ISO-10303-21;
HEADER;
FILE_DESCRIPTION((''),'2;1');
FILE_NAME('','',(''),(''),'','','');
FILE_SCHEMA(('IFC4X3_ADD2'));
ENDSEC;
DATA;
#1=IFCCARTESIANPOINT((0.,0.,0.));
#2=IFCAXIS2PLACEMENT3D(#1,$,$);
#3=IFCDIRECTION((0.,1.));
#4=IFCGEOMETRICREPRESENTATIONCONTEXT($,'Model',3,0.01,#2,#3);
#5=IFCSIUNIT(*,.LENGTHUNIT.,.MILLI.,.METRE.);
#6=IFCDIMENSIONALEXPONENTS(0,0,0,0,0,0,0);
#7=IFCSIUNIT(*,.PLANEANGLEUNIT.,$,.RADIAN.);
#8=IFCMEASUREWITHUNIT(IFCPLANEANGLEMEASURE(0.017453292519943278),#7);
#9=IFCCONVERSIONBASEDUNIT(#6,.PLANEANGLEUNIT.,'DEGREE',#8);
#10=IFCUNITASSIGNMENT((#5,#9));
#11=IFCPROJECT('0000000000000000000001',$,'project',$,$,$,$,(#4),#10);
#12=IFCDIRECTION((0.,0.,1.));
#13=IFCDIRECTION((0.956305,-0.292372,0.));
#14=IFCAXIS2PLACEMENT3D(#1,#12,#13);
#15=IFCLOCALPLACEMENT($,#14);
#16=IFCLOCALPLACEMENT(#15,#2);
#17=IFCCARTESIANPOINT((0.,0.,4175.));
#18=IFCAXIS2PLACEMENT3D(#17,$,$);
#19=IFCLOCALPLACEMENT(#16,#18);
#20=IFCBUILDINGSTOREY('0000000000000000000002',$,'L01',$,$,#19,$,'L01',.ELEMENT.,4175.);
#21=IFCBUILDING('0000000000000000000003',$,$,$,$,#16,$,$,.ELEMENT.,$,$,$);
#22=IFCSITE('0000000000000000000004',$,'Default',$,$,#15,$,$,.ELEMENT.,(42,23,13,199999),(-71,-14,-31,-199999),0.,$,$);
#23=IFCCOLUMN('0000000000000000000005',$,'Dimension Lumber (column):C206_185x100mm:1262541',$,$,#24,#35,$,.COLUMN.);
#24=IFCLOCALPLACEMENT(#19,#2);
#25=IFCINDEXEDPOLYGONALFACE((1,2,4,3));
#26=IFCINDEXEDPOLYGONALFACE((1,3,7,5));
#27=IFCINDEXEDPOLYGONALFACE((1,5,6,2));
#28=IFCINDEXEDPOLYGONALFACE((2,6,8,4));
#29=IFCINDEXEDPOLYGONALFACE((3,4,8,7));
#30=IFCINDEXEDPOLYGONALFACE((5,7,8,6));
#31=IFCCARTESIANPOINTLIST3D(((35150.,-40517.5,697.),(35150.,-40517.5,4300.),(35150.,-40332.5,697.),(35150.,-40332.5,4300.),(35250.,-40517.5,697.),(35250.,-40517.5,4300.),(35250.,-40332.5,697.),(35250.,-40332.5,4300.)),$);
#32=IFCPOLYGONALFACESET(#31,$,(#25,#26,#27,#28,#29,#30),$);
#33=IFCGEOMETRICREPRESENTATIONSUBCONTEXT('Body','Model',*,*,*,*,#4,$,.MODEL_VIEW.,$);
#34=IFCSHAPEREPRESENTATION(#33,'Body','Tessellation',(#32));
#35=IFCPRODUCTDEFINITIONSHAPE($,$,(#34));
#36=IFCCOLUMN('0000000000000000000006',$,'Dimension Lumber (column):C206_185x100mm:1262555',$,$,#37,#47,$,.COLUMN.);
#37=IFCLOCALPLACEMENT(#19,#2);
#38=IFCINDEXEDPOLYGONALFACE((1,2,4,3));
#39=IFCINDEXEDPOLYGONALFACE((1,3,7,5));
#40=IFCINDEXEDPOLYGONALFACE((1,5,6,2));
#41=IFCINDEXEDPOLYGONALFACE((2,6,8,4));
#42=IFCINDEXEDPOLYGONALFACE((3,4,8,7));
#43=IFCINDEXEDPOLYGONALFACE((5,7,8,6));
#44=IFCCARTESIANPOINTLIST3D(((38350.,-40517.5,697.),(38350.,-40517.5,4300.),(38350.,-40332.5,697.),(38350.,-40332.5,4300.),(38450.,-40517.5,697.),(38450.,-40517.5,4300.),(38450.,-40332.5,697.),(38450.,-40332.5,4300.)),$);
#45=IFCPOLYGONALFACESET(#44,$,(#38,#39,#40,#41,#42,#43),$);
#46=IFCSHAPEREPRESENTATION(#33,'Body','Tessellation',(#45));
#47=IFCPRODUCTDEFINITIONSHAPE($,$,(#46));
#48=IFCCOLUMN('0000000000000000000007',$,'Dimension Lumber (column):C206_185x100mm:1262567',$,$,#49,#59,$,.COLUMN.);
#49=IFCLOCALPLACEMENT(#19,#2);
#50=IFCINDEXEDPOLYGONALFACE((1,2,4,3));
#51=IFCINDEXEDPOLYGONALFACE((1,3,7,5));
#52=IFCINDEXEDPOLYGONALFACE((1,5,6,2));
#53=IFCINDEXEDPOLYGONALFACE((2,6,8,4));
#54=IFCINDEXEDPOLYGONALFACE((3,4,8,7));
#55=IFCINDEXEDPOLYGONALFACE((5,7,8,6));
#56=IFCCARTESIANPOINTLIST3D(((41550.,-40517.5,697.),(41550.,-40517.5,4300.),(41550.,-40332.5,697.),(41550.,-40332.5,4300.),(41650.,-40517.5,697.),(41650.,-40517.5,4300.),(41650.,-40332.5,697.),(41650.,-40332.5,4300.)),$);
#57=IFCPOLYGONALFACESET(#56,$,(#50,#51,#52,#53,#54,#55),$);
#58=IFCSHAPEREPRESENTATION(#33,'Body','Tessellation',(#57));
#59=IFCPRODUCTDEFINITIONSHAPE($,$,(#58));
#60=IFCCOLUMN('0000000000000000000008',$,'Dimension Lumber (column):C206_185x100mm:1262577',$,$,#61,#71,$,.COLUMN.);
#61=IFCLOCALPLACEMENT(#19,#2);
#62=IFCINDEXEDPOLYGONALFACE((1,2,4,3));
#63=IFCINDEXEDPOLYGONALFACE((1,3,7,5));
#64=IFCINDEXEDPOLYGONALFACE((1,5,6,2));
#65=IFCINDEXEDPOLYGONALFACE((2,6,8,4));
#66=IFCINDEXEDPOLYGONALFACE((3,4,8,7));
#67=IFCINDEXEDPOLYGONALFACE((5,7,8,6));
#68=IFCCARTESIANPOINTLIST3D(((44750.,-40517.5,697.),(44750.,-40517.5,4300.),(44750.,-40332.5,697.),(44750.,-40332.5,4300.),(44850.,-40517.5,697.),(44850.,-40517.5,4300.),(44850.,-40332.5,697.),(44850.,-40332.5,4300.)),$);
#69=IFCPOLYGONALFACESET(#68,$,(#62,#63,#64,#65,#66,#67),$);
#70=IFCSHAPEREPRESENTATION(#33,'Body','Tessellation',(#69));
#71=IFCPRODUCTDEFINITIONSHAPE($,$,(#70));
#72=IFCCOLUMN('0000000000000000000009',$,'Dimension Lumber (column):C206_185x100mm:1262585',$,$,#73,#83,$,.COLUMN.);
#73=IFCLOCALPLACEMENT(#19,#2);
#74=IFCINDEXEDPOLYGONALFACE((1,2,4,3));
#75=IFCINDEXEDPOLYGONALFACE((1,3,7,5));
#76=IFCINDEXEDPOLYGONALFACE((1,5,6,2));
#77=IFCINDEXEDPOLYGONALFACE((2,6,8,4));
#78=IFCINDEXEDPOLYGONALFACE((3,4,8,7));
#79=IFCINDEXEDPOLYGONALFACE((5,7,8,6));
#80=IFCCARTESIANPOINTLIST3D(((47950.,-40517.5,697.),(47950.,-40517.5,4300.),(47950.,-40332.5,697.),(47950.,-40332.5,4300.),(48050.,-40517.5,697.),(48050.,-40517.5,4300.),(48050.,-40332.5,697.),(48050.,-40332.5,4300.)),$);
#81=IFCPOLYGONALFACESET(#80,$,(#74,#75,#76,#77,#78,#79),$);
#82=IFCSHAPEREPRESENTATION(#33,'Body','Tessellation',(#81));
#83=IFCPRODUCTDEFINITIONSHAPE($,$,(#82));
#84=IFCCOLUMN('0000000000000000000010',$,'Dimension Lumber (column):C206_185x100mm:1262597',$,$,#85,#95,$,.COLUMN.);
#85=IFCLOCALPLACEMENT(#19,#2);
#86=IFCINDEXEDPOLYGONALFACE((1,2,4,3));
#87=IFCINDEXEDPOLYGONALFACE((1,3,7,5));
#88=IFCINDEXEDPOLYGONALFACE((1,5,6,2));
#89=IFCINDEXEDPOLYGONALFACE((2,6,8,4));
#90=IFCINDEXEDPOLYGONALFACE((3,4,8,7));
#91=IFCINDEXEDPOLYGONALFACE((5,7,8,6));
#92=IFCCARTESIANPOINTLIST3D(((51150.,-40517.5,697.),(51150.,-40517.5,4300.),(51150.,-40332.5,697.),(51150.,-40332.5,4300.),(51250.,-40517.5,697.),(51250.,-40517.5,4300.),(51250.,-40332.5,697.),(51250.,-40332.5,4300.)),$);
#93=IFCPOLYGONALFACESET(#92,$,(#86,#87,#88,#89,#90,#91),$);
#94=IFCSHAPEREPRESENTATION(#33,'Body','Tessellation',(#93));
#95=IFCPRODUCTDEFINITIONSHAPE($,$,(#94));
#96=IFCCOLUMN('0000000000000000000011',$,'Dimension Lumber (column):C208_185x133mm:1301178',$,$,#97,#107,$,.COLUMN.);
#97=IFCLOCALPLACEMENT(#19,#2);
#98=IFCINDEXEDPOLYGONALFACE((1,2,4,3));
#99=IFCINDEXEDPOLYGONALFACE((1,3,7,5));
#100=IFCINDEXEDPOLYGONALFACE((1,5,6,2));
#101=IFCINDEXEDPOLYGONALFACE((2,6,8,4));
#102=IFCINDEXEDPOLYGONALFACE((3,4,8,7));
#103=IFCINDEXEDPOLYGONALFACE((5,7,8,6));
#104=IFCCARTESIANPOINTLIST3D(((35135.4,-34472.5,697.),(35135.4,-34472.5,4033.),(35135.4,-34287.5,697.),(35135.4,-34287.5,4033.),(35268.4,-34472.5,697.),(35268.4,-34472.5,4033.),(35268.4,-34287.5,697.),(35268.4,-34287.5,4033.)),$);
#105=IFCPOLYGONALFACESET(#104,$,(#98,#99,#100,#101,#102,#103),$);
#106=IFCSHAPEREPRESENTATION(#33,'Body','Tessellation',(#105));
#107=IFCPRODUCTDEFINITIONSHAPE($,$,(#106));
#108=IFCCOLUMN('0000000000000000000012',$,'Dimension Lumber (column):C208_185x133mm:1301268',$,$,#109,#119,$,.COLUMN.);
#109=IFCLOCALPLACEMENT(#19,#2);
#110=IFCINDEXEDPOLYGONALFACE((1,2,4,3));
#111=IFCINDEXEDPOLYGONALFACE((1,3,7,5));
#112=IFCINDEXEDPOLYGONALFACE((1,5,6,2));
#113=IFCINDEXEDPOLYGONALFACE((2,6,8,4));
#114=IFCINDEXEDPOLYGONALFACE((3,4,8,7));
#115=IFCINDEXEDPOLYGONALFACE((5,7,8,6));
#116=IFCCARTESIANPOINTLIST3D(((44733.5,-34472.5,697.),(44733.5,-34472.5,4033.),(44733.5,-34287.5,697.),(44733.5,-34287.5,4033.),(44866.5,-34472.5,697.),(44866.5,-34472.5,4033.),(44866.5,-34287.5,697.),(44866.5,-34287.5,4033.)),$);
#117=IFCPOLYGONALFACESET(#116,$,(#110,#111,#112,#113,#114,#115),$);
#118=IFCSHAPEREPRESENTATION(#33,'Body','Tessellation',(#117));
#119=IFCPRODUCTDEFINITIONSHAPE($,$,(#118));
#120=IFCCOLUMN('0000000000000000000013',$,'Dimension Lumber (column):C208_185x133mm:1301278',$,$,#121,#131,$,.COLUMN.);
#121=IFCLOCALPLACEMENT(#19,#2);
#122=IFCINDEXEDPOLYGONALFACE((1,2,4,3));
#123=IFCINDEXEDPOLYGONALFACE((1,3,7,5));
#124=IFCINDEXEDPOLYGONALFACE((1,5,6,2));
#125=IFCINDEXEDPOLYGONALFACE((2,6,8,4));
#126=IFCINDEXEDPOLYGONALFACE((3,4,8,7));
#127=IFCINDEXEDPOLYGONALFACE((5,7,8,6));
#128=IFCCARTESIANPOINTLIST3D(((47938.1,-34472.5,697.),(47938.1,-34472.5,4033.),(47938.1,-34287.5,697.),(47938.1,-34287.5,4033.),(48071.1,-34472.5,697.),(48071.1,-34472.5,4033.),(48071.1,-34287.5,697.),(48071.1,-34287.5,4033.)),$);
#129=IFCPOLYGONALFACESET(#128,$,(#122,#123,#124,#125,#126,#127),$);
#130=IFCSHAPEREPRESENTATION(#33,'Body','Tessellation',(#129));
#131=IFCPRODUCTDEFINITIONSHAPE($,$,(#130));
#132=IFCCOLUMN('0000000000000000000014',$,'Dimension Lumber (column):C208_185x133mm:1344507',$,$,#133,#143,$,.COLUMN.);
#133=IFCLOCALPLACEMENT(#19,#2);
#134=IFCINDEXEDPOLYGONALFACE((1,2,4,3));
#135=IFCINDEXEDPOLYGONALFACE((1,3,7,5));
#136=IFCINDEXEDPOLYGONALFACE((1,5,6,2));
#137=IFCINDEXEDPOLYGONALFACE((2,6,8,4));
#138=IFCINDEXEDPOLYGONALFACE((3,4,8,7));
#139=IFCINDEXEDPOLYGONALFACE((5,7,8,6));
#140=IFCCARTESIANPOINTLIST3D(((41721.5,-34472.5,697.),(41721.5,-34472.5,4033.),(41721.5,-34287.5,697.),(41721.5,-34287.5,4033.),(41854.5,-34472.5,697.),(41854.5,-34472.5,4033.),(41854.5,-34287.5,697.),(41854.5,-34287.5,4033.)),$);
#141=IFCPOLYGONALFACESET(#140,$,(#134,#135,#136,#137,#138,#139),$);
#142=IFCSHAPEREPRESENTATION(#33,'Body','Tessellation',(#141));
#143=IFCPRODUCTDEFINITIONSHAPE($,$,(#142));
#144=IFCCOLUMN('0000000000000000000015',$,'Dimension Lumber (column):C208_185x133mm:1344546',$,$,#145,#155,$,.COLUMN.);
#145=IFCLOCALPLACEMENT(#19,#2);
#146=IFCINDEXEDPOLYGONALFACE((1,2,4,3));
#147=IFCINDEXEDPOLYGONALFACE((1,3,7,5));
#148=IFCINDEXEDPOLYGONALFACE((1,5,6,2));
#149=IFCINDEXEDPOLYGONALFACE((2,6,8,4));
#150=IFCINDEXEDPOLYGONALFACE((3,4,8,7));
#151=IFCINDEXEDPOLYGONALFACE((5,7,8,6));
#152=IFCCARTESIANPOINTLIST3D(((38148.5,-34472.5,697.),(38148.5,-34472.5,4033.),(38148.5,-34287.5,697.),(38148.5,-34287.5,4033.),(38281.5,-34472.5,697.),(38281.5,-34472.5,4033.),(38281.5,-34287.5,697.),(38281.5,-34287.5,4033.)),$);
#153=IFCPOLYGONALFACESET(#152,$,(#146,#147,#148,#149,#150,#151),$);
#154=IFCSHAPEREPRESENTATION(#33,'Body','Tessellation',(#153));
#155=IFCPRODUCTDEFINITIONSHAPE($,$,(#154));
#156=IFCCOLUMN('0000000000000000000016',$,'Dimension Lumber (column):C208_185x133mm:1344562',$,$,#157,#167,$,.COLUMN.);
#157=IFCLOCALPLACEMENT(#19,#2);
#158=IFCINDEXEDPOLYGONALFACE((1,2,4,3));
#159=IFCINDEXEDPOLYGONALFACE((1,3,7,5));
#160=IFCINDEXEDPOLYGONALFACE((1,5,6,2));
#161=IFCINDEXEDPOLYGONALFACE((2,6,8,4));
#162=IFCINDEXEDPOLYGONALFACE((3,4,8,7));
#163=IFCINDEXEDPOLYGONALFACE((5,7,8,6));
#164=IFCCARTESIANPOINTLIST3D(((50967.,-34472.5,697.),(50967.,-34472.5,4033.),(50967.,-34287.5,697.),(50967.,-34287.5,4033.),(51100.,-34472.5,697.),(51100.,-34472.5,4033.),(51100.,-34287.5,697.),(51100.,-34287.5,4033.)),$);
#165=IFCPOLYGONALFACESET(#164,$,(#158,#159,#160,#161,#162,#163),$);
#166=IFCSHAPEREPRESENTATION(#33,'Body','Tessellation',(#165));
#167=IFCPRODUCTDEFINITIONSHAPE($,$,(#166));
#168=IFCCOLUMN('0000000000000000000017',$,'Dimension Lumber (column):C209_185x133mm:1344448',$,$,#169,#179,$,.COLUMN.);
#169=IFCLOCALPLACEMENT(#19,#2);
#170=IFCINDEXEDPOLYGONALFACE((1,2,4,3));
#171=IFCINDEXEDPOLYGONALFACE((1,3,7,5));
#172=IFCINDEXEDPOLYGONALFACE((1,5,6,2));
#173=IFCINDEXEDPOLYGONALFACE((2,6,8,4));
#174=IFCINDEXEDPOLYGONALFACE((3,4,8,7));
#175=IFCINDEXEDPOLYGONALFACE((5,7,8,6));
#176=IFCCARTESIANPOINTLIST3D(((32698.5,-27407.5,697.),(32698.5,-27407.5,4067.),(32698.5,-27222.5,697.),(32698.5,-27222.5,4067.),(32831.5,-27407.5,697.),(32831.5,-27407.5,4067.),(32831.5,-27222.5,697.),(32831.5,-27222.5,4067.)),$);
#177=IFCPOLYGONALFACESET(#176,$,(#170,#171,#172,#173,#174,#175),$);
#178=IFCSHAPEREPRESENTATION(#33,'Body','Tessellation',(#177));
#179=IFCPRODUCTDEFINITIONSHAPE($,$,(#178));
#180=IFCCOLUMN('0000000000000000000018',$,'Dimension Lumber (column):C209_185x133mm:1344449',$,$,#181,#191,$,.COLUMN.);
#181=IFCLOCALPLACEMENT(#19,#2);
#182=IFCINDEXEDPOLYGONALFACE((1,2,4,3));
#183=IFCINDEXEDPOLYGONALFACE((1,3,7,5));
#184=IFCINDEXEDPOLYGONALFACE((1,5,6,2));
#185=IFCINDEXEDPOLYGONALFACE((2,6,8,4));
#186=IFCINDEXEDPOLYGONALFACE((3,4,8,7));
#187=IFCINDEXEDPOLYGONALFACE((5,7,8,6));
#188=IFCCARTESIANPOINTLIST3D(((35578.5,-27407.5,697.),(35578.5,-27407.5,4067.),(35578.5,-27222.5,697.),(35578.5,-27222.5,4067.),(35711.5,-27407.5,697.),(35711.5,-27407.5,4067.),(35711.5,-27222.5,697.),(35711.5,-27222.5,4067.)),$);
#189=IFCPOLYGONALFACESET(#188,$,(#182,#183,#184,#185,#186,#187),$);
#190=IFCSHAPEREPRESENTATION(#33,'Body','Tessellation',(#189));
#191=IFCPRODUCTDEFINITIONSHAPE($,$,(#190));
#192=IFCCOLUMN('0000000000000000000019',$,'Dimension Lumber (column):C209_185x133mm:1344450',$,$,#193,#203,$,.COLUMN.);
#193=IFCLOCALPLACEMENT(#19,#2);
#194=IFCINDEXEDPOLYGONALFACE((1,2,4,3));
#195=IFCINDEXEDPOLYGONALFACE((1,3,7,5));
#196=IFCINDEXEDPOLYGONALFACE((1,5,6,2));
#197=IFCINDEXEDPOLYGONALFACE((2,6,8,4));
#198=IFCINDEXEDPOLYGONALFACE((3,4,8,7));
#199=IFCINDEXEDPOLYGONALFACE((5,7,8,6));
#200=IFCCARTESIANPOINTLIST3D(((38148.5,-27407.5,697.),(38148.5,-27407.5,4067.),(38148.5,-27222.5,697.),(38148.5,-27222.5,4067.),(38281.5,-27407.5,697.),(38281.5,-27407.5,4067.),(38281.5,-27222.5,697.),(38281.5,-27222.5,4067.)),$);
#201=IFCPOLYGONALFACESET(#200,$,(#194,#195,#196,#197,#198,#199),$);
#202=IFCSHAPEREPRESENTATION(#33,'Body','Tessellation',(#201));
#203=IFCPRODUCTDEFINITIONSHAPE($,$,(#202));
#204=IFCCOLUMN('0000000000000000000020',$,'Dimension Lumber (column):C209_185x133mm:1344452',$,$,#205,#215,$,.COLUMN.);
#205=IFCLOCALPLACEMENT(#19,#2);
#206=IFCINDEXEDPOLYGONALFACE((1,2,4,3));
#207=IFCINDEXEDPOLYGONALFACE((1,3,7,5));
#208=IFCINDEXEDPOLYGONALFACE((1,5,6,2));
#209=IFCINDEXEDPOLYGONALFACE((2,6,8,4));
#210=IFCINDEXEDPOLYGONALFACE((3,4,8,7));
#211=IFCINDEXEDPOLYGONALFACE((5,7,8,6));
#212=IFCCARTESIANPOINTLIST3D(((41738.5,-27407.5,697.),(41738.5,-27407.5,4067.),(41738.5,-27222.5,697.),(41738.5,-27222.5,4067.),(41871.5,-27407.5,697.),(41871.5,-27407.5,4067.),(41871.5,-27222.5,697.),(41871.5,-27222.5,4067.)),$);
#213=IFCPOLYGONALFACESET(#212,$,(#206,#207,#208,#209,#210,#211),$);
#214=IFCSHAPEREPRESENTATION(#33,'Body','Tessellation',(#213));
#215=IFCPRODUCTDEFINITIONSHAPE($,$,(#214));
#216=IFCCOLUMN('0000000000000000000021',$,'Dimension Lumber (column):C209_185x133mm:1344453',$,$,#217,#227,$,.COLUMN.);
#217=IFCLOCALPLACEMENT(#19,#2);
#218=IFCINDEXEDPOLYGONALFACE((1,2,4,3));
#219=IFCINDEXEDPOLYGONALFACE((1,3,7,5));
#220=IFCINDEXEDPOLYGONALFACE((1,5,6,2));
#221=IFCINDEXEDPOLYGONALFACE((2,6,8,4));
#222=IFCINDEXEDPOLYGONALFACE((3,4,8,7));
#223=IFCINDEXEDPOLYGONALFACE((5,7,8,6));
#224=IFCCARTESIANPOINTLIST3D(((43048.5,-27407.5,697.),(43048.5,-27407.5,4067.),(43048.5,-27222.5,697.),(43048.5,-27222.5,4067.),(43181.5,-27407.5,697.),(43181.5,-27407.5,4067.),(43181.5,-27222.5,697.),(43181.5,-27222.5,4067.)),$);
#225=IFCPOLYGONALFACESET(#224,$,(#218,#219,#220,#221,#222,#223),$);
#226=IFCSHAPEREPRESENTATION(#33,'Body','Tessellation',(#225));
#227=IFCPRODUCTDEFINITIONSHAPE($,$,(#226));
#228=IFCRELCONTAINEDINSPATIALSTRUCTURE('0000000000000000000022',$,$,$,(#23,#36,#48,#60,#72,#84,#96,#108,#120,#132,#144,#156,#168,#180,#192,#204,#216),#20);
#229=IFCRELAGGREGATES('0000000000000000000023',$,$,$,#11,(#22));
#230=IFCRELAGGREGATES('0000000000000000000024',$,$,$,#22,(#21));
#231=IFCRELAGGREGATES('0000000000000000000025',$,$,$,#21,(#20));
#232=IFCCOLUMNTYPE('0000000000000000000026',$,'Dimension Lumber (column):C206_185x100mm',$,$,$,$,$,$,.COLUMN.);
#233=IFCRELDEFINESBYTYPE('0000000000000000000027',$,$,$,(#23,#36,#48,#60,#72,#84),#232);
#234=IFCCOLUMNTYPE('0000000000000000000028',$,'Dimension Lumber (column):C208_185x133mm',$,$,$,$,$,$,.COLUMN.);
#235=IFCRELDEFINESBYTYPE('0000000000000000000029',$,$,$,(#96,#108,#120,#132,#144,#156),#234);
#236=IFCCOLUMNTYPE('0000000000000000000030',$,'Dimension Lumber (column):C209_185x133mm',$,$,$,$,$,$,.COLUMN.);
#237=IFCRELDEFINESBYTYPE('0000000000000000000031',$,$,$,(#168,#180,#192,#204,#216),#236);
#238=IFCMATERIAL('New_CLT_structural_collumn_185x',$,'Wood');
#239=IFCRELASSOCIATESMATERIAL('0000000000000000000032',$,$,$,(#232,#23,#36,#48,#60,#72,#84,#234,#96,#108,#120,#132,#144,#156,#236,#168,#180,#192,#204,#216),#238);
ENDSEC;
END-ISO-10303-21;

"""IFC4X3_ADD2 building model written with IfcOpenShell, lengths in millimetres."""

from ifc_helpers import new_model, entity, si_unit, converted_unit, direction, frame, origin, origin_2d_with_axis, place, context, subcontext, project, spatial, rectangle, extrude, source, transform, mapped, material, material_profile, profile_set, profile_usage, type_object, type_shapes, element, save


model = new_model("IFC4X3_ADD2")

# Units and contexts
model_context = context("Model", 3, precision=0.01, world=origin(), true_north=direction((0.0, 1.0)))
body_context = subcontext(model_context, "Body", "Model", "MODEL_VIEW")
ifc_project = project(units=[si_unit("LENGTHUNIT", "METRE", prefix="MILLI"), converted_unit("PLANEANGLEUNIT", "DEGREE", entity("IfcPlaneAngleMeasure", 0.017453292519943278), si_unit("PLANEANGLEUNIT", "RADIAN"), dimensions=[0, 0, 0, 0, 0, 0, 0])], contexts=[model_context])

# Site, building, storey
site_placement = place(None, frame((0.0, 0.0, 0.0), z_axis=(0.0, 0.0, 1.0), x_axis=(0.956305, -0.292372, 0.0)))
site = spatial("IfcSite", under=ifc_project, at=site_placement, Name="Default", CompositionType="ELEMENT", RefLatitude=(42, 23, 13, 199999), RefLongitude=(-71, -14, -31, -199999), RefElevation=0.0)
building_placement = place(site_placement, origin())
building = spatial("IfcBuilding", under=site, at=building_placement, CompositionType="ELEMENT")
storey_placement = place(building_placement, frame((0.0, 0.0, 4175.0)))
storey = spatial("IfcBuildingStorey", under=building, at=storey_placement, Name="L01", LongName="L01", CompositionType="ELEMENT", Elevation=4175.0)

# Columns
ifc_material_1 = material(Name="New_CLT_structural_collumn_185x", Category="Wood")
ifc_material_profile_1 = material_profile(ifc_material_1, rectangle(XDim=185.0, YDim=100.0, at=origin_2d_with_axis()), Name="C206_185x100mm")
ifc_profile_set_1 = profile_set([ifc_material_profile_1], Name="C206_185x100mm")
ifc_profile_usage_1 = profile_usage(ifc_profile_set_1)
column_type_1 = type_object("IfcColumnType", Name="Dimension Lumber (column):C206_185x100mm", PredefinedType="COLUMN", material=ifc_profile_set_1)
shared_shape_1 = source(origin(), body_context, "Body", "SweptSolid", [
    extrude(rectangle(XDim=185.0, YDim=100.0, at=origin_2d_with_axis()), frame((0.0, 0.0, 4872.0), z_axis=(0.0, 0.0, 1.0), x_axis=(-1.0, 0.0, 0.0)), (0.0, 0.0, 1.0), 3603.0),
])
type_shapes(column_type_1, [shared_shape_1])
for number, where, z_axis, x_axis, name in (
    (1, (35200.0, -40425.0, -4175.0), (0.0, 0.0, 1.0), (0.0, 1.0, 0.0), "Dimension Lumber (column):C206_185x100mm:1262541"),
    (2, (38400.0, -40425.0, -4175.0), (0.0, 0.0, 1.0), (0.0, 1.0, 0.0), "Dimension Lumber (column):C206_185x100mm:1262555"),
    (3, (41600.0, -40425.0, -4175.0), (0.0, 0.0, 1.0), (0.0, 1.0, 0.0), "Dimension Lumber (column):C206_185x100mm:1262567"),
    (4, (44800.0, -40425.0, -4175.0), (0.0, 0.0, 1.0), (0.0, 1.0, 0.0), "Dimension Lumber (column):C206_185x100mm:1262577"),
    (5, (48000.0, -40425.0, -4175.0), (0.0, 0.0, 1.0), (0.0, 1.0, 0.0), "Dimension Lumber (column):C206_185x100mm:1262585"),
    (6, (51200.0, -40425.0, -4175.0), (0.0, 0.0, 1.0), (0.0, 1.0, 0.0), "Dimension Lumber (column):C206_185x100mm:1262597"),
):
    element("IfcColumn", number, at=place(storey_placement, frame(where, z_axis=z_axis, x_axis=x_axis)), inside=storey, type_object=column_type_1, material=ifc_profile_usage_1, Name=name, PredefinedType="COLUMN", context=body_context, shape_type="MappedRepresentation", body=[
        mapped(shared_shape_1, transform((0.0, 0.0, 0.0), scale=1.0)),
    ])
ifc_material_profile_2 = material_profile(ifc_material_1, rectangle(XDim=185.0, YDim=133.0, at=origin_2d_with_axis()), Name="C208_185x133mm")
ifc_profile_set_2 = profile_set([ifc_material_profile_2], Name="C208_185x133mm")
ifc_profile_usage_2 = profile_usage(ifc_profile_set_2)
column_type_2 = type_object("IfcColumnType", Name="Dimension Lumber (column):C208_185x133mm", PredefinedType="COLUMN", material=ifc_profile_set_2)
shared_shape_2 = source(origin(), body_context, "Body", "SweptSolid", [
    extrude(rectangle(XDim=185.0, YDim=133.0, at=origin_2d_with_axis()), frame((0.0, 0.0, 4872.0), z_axis=(0.0, 0.0, 1.0), x_axis=(-1.0, 0.0, 0.0)), (0.0, 0.0, 1.0), 3336.0),
])
type_shapes(column_type_2, [shared_shape_2])
for number, where, z_axis, x_axis, name in (
    (7, (35201.9, -34380.0, -4175.0), (0.0, 0.0, 1.0), (0.0, 1.0, 0.0), "Dimension Lumber (column):C208_185x133mm:1301178"),
    (8, (44800.0, -34380.0, -4175.0), (0.0, 0.0, 1.0), (0.0, 1.0, 0.0), "Dimension Lumber (column):C208_185x133mm:1301268"),
    (9, (48004.6, -34380.0, -4175.0), (0.0, 0.0, 1.0), (0.0, 1.0, 0.0), "Dimension Lumber (column):C208_185x133mm:1301278"),
    (10, (41788.0, -34380.0, -4175.0), (0.0, 0.0, 1.0), (0.0, 1.0, 0.0), "Dimension Lumber (column):C208_185x133mm:1344507"),
    (11, (38215.0, -34380.0, -4175.0), (0.0, 0.0, 1.0), (0.0, 1.0, 0.0), "Dimension Lumber (column):C208_185x133mm:1344546"),
    (12, (51033.5, -34380.0, -4175.0), (0.0, 0.0, 1.0), (0.0, 1.0, 0.0), "Dimension Lumber (column):C208_185x133mm:1344562"),
):
    element("IfcColumn", number, at=place(storey_placement, frame(where, z_axis=z_axis, x_axis=x_axis)), inside=storey, type_object=column_type_2, material=ifc_profile_usage_2, Name=name, PredefinedType="COLUMN", context=body_context, shape_type="MappedRepresentation", body=[
        mapped(shared_shape_2, transform((0.0, 0.0, 0.0), scale=1.0)),
    ])
ifc_material_profile_3 = material_profile(ifc_material_1, rectangle(XDim=185.0, YDim=133.0, at=origin_2d_with_axis()), Name="C209_185x133mm")
ifc_profile_set_3 = profile_set([ifc_material_profile_3], Name="C209_185x133mm")
ifc_profile_usage_3 = profile_usage(ifc_profile_set_3)
column_type_3 = type_object("IfcColumnType", Name="Dimension Lumber (column):C209_185x133mm", PredefinedType="COLUMN", material=ifc_profile_set_3)
shared_shape_3 = source(origin(), body_context, "Body", "SweptSolid", [
    extrude(rectangle(XDim=185.0, YDim=133.0, at=origin_2d_with_axis()), frame((0.0, 0.0, 4872.0), z_axis=(0.0, 0.0, 1.0), x_axis=(-1.0, 0.0, 0.0)), (0.0, 0.0, 1.0), 3370.0),
])
type_shapes(column_type_3, [shared_shape_3])
for number, where, z_axis, x_axis, name in (
    (13, (32765.0, -27315.0, -4175.0), (0.0, 0.0, 1.0), (0.0, 1.0, 0.0), "Dimension Lumber (column):C209_185x133mm:1344448"),
    (14, (35645.0, -27315.0, -4175.0), (0.0, 0.0, 1.0), (0.0, 1.0, 0.0), "Dimension Lumber (column):C209_185x133mm:1344449"),
    (15, (38215.0, -27315.0, -4175.0), (0.0, 0.0, 1.0), (0.0, 1.0, 0.0), "Dimension Lumber (column):C209_185x133mm:1344450"),
    (16, (41805.0, -27315.0, -4175.0), (0.0, 0.0, 1.0), (0.0, 1.0, 0.0), "Dimension Lumber (column):C209_185x133mm:1344452"),
    (17, (43115.0, -27315.0, -4175.0), (0.0, 0.0, 1.0), (0.0, 1.0, 0.0), "Dimension Lumber (column):C209_185x133mm:1344453"),
):
    element("IfcColumn", number, at=place(storey_placement, frame(where, z_axis=z_axis, x_axis=x_axis)), inside=storey, type_object=column_type_3, material=ifc_profile_usage_3, Name=name, PredefinedType="COLUMN", context=body_context, shape_type="MappedRepresentation", body=[
        mapped(shared_shape_3, transform((0.0, 0.0, 0.0), scale=1.0)),
    ])

save(model, "model.ifc")
